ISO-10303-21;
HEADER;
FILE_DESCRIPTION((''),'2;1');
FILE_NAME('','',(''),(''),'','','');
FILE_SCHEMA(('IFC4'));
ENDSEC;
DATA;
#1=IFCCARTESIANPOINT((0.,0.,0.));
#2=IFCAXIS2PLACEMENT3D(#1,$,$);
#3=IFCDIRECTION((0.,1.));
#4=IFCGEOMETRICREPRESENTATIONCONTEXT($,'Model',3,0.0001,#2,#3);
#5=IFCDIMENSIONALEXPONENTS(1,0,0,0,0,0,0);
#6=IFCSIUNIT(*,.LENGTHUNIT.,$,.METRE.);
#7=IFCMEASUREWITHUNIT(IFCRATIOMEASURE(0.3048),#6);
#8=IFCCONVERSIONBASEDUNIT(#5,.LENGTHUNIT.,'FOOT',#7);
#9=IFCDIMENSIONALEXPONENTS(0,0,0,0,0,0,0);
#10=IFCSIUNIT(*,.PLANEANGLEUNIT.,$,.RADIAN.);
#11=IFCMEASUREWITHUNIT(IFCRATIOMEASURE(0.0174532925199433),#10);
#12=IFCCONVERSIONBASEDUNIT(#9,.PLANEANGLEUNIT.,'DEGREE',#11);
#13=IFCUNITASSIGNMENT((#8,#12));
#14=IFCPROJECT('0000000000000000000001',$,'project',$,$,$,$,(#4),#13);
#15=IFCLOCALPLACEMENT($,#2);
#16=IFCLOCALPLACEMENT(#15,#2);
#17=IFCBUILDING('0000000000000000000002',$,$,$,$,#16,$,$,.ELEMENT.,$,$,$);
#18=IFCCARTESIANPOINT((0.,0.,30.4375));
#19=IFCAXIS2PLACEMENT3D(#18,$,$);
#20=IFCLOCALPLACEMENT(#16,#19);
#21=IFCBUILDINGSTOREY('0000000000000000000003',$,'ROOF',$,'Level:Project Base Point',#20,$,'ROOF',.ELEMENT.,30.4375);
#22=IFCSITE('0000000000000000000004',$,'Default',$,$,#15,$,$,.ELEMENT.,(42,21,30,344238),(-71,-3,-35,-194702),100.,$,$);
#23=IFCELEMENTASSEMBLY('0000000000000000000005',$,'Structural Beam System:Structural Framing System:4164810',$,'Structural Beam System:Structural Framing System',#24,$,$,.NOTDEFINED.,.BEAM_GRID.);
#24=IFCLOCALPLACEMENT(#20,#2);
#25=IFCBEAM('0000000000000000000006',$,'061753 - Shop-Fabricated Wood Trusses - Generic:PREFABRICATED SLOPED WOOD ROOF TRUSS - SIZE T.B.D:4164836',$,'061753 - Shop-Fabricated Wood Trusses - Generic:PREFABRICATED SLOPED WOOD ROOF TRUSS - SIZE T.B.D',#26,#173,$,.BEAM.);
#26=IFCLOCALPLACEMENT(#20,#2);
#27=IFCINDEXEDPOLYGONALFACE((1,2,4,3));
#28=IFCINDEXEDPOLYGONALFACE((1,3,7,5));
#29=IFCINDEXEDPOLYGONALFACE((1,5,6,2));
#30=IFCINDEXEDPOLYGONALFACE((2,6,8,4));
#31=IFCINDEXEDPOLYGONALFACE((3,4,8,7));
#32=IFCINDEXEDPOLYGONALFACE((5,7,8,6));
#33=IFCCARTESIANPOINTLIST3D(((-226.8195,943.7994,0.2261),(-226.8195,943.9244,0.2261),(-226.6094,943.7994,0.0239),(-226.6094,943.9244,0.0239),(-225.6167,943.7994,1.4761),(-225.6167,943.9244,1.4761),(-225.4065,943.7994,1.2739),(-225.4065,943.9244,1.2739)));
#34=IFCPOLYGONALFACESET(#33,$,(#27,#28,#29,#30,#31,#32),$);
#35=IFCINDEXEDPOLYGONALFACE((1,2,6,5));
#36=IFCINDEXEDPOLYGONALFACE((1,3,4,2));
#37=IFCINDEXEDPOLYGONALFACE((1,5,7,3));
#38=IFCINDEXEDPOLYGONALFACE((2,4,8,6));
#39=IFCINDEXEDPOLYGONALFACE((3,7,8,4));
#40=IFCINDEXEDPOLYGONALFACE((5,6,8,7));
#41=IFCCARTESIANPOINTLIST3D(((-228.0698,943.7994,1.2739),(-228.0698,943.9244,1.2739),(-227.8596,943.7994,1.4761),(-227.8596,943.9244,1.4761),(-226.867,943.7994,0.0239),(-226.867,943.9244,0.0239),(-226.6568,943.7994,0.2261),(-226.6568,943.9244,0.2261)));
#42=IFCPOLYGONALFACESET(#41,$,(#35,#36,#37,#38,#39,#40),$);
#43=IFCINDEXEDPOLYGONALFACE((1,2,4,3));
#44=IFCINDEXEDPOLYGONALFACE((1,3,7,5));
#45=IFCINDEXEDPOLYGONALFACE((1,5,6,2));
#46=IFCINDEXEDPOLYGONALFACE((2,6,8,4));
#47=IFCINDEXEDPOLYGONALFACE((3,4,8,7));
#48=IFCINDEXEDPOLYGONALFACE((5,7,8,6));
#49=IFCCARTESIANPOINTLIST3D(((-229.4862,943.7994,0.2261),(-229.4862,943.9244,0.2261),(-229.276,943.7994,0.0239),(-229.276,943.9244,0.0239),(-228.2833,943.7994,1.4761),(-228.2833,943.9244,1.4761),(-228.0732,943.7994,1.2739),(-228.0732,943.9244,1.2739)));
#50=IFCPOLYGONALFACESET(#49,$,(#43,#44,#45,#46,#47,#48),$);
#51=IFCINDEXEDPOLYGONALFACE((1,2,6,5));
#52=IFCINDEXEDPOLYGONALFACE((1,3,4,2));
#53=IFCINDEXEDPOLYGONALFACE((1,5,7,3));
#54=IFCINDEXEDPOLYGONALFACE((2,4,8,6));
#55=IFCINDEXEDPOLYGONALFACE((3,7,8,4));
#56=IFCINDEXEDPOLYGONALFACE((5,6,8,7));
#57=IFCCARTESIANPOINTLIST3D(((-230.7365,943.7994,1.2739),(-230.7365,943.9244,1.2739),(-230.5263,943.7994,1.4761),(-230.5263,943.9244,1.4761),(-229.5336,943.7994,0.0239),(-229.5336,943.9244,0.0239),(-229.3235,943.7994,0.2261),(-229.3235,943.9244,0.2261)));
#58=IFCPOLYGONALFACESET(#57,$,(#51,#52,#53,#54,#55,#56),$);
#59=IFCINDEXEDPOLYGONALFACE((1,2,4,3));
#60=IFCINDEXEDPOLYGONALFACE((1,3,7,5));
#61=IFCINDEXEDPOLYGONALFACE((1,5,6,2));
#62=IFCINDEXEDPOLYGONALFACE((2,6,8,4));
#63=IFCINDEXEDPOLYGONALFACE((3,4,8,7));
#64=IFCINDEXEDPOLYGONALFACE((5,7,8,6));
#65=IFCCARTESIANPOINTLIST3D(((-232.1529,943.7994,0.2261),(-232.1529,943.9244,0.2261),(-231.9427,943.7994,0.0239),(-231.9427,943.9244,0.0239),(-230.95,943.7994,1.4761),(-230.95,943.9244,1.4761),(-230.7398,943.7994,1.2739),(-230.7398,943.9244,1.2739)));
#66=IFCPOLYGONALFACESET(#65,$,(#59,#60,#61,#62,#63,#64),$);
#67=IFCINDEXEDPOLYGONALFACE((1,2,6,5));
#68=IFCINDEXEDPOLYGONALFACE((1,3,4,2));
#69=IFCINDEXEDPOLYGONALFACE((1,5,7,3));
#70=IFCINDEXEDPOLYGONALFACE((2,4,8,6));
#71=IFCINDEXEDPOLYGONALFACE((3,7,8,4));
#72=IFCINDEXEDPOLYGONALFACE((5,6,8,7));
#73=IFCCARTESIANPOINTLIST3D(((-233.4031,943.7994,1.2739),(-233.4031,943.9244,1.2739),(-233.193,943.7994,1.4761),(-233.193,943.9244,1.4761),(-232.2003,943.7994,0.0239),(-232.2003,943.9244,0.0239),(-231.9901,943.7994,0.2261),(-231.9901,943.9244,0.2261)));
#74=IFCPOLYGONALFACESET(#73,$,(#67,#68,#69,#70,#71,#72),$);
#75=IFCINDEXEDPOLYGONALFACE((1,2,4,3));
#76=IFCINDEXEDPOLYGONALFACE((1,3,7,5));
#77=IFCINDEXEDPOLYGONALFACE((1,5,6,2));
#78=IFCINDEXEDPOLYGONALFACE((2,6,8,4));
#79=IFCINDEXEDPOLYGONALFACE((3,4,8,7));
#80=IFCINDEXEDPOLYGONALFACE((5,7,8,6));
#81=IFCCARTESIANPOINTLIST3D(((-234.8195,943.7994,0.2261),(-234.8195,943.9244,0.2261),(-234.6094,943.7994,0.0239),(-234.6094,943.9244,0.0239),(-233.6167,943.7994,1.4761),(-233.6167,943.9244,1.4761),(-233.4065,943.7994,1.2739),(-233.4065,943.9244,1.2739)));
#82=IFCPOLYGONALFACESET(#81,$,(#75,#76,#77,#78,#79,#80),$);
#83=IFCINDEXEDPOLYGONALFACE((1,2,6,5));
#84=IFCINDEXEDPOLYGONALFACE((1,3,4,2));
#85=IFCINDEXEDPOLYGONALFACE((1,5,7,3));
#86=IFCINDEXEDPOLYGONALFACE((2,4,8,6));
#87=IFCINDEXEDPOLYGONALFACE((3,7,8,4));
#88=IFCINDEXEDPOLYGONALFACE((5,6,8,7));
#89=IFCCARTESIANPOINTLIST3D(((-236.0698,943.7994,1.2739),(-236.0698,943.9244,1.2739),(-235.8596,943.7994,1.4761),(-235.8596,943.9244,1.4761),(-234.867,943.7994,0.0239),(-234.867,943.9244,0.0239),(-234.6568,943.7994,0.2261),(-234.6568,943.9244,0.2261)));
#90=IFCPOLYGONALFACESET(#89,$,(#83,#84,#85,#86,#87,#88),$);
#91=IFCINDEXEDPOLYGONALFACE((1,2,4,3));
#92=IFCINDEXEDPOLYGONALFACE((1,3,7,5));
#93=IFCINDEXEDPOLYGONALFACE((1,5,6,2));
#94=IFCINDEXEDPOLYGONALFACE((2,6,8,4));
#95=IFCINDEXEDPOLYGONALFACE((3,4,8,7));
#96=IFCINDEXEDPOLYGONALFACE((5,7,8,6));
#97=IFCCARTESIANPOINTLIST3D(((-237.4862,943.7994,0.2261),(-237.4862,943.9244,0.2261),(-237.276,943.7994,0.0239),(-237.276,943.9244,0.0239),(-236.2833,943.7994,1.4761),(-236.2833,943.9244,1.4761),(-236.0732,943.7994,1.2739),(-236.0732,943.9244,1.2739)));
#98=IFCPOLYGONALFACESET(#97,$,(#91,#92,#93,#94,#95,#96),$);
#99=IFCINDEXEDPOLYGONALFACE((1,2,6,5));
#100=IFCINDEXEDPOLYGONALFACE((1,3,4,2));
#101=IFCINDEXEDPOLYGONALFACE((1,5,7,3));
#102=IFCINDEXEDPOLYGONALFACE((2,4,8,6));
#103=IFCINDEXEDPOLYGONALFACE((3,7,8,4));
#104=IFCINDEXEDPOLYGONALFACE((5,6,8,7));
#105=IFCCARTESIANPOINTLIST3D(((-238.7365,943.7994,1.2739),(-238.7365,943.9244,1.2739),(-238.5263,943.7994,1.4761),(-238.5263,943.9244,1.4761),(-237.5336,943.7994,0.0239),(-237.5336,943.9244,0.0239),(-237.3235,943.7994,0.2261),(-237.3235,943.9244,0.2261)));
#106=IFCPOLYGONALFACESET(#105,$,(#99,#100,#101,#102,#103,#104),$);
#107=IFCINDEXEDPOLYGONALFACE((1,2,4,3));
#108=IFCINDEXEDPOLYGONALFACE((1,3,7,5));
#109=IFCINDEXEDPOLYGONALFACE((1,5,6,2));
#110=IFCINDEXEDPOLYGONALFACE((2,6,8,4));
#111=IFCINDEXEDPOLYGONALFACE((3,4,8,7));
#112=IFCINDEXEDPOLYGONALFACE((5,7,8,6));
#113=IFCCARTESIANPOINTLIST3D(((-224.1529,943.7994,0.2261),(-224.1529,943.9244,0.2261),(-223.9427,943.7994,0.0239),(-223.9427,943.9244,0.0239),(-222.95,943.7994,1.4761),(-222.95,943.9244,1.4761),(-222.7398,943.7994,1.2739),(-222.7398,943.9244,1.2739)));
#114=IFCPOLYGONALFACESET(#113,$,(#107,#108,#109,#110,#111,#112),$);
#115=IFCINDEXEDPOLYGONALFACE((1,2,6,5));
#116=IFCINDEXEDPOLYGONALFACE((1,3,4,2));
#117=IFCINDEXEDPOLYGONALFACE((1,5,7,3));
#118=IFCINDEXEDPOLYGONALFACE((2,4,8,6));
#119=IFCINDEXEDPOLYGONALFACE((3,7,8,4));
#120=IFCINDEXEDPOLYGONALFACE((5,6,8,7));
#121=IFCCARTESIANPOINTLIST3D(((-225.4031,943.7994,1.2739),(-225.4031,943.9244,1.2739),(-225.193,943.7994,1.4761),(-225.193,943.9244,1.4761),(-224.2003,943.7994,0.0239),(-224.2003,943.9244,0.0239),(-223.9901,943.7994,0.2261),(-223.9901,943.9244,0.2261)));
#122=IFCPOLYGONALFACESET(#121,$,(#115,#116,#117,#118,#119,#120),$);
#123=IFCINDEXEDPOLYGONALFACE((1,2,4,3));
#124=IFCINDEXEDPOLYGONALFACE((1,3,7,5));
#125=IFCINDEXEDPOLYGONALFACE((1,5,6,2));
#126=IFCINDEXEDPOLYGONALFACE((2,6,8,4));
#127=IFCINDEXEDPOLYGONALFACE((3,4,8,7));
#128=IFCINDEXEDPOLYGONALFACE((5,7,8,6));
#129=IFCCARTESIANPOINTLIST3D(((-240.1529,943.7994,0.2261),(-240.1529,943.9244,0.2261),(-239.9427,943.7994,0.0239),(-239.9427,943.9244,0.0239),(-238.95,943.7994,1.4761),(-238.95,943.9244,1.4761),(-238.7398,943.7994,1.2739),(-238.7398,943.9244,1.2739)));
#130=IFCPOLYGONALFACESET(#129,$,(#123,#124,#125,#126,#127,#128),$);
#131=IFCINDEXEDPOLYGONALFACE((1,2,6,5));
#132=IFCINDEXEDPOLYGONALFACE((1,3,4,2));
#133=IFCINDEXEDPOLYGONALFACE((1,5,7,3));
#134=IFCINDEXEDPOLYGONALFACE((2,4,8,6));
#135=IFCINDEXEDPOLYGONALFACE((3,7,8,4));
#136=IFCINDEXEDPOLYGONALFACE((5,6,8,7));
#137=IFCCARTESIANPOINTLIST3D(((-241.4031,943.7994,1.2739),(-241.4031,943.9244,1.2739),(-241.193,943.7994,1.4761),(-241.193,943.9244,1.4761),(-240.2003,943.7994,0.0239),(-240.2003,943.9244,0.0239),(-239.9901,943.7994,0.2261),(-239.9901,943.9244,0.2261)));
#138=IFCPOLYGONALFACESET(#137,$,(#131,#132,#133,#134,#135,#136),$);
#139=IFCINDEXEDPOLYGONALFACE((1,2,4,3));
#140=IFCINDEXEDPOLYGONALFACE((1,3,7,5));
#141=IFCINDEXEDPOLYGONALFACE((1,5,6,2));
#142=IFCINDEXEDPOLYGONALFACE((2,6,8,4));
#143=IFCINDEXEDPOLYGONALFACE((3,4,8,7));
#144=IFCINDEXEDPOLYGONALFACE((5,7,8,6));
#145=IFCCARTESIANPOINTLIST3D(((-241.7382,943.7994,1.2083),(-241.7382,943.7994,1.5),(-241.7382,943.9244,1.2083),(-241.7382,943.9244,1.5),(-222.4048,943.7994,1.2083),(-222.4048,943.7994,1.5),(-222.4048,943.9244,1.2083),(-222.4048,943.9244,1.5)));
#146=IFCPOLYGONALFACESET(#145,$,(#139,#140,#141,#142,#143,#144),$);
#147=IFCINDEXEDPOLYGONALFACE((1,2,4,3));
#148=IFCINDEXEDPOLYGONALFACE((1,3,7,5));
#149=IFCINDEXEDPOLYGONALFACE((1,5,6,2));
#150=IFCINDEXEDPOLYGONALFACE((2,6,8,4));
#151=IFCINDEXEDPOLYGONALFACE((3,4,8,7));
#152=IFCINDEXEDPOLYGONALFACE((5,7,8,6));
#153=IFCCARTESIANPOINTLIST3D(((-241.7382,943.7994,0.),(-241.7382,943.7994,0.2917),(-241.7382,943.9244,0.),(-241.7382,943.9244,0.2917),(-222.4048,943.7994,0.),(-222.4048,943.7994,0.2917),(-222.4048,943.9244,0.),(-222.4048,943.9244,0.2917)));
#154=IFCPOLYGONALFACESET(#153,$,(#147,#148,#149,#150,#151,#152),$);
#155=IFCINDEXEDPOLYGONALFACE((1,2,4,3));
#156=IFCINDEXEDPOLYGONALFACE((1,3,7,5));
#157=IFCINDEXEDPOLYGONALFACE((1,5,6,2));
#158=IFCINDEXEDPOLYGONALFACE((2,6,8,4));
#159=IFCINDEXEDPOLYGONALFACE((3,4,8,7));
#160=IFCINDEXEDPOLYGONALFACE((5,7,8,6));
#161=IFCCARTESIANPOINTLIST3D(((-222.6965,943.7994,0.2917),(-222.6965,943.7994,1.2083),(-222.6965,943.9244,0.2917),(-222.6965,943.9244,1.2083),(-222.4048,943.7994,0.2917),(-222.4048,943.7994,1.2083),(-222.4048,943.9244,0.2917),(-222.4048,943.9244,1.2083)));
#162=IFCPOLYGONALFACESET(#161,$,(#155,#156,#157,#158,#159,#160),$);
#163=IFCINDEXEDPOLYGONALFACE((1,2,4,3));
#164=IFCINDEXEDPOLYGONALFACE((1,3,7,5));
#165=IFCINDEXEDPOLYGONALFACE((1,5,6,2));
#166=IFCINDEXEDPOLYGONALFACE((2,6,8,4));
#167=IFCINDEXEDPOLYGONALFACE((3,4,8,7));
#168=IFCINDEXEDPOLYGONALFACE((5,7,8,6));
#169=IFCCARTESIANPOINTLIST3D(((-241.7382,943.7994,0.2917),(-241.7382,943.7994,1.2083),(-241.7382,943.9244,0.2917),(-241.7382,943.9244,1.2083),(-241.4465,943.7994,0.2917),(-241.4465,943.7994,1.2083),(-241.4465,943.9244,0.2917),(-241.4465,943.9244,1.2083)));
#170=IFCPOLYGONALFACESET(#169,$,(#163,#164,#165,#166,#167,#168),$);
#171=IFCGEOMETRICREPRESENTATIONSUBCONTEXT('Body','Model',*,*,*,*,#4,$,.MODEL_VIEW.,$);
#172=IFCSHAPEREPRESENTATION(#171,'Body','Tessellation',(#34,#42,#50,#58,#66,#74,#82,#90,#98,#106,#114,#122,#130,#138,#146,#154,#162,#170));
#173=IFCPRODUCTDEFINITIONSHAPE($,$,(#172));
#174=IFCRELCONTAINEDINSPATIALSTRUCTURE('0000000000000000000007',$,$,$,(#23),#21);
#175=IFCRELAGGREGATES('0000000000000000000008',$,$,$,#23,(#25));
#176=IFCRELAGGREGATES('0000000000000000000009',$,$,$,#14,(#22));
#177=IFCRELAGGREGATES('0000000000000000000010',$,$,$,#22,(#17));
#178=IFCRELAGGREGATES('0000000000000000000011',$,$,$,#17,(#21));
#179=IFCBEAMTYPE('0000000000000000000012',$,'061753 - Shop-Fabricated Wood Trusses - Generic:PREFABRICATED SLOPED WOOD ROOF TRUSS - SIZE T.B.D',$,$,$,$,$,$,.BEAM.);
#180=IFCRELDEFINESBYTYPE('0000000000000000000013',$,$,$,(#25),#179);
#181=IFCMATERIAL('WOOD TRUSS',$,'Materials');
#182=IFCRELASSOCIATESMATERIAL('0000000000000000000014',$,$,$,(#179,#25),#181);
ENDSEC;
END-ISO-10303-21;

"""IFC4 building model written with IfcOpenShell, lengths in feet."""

from ifc_helpers import new_model, entity, si_unit, converted_unit, direction, frame, frame_2d, origin, origin_2d_with_axis, place, context, subcontext, project, spatial, rectangle, extrude, source, transform, mapped, material, material_profile, profile_set, profile_usage, type_object, type_shapes, element, aggregate, save


model = new_model("IFC4")

# Units and contexts
model_context = context("Model", 3, precision=0.0001, world=origin(), true_north=direction((0.0, 1.0)))
body_context = subcontext(model_context, "Body", "Model", "MODEL_VIEW")
ifc_project = project(units=[converted_unit("LENGTHUNIT", "FOOT", entity("IfcRatioMeasure", 0.3048), si_unit("LENGTHUNIT", "METRE"), dimensions=[1, 0, 0, 0, 0, 0, 0]), converted_unit("PLANEANGLEUNIT", "DEGREE", entity("IfcRatioMeasure", 0.0174532925199433), si_unit("PLANEANGLEUNIT", "RADIAN"), dimensions=[0, 0, 0, 0, 0, 0, 0])], contexts=[model_context])

# Site, building, storey
site_placement = place(None, origin())
site = spatial("IfcSite", under=ifc_project, at=site_placement, Name="Default", CompositionType="ELEMENT", RefLatitude=(42, 21, 30, 344238), RefLongitude=(-71, -3, -35, -194702), RefElevation=100.0)
building_placement = place(site_placement, origin())
building = spatial("IfcBuilding", under=site, at=building_placement, CompositionType="ELEMENT")
storey_placement = place(building_placement, frame((0.0, 0.0, 30.4375)))
storey = spatial("IfcBuildingStorey", under=building, at=storey_placement, Name="ROOF", ObjectType="Level:Project Base Point", LongName="ROOF", CompositionType="ELEMENT", Elevation=30.4375)

# Element assembly, beam
assembly_1_placement = place(storey_placement, origin())
assembly_1 = element("IfcElementAssembly", 1, at=assembly_1_placement, inside=storey, Name="Structural Beam System:Structural Framing System:4164810", ObjectType="Structural Beam System:Structural Framing System", AssemblyPlace="NOTDEFINED", PredefinedType="BEAM_GRID")
ifc_material_1 = material(Name="WOOD TRUSS", Category="Materials")
ifc_material_profile_1 = material_profile(ifc_material_1, rectangle(XDim=1.7347, YDim=0.125, at=origin_2d_with_axis()), Name="PREFABRICATED SLOPED WOOD ROOF TRUSS - SIZE T.B.D")
ifc_material_profile_2 = material_profile(ifc_material_1, rectangle(XDim=1.7347, YDim=0.125, at=frame_2d((0.0, 0.0), x_axis=(1.0, 0.0))), Name="PREFABRICATED SLOPED WOOD ROOF TRUSS - SIZE T.B.D")
ifc_material_profile_3 = material_profile(ifc_material_1, rectangle(XDim=1.7347, YDim=0.125, at=origin_2d_with_axis()), Name="PREFABRICATED SLOPED WOOD ROOF TRUSS - SIZE T.B.D")
ifc_material_profile_4 = material_profile(ifc_material_1, rectangle(XDim=1.7347, YDim=0.125, at=origin_2d_with_axis()), Name="PREFABRICATED SLOPED WOOD ROOF TRUSS - SIZE T.B.D")
ifc_material_profile_5 = material_profile(ifc_material_1, rectangle(XDim=1.7347, YDim=0.125, at=frame_2d((0.0, 0.0), x_axis=(1.0, 0.0))), Name="PREFABRICATED SLOPED WOOD ROOF TRUSS - SIZE T.B.D")
ifc_material_profile_6 = material_profile(ifc_material_1, rectangle(XDim=1.7347, YDim=0.125, at=frame_2d((0.0, 0.0), x_axis=(1.0, 0.0))), Name="PREFABRICATED SLOPED WOOD ROOF TRUSS - SIZE T.B.D")
ifc_material_profile_7 = material_profile(ifc_material_1, rectangle(XDim=1.7347, YDim=0.125, at=frame_2d((0.0, 0.0), x_axis=(1.0, 0.0))), Name="PREFABRICATED SLOPED WOOD ROOF TRUSS - SIZE T.B.D")
ifc_material_profile_8 = material_profile(ifc_material_1, rectangle(XDim=1.7347, YDim=0.125, at=frame_2d((0.0, 0.0), x_axis=(1.0, 0.0))), Name="PREFABRICATED SLOPED WOOD ROOF TRUSS - SIZE T.B.D")
ifc_material_profile_9 = material_profile(ifc_material_1, rectangle(XDim=1.7347, YDim=0.125, at=origin_2d_with_axis()), Name="PREFABRICATED SLOPED WOOD ROOF TRUSS - SIZE T.B.D")
ifc_material_profile_10 = material_profile(ifc_material_1, rectangle(XDim=1.7347, YDim=0.125, at=frame_2d((0.0, 0.0), x_axis=(1.0, 0.0))), Name="PREFABRICATED SLOPED WOOD ROOF TRUSS - SIZE T.B.D")
ifc_material_profile_11 = material_profile(ifc_material_1, rectangle(XDim=0.2917, YDim=0.125, at=frame_2d((0.0, 0.0), x_axis=(1.0, 0.0))), Name="PREFABRICATED SLOPED WOOD ROOF TRUSS - SIZE T.B.D")
ifc_material_profile_12 = material_profile(ifc_material_1, rectangle(XDim=0.2917, YDim=0.125, at=frame_2d((0.0, 0.0), x_axis=(1.0, 0.0))), Name="PREFABRICATED SLOPED WOOD ROOF TRUSS - SIZE T.B.D")
ifc_material_profile_13 = material_profile(ifc_material_1, rectangle(XDim=0.9167, YDim=0.125, at=frame_2d((0.0, 0.0), x_axis=(1.0, 0.0))), Name="PREFABRICATED SLOPED WOOD ROOF TRUSS - SIZE T.B.D")
ifc_material_profile_14 = material_profile(ifc_material_1, rectangle(XDim=0.9167, YDim=0.125, at=frame_2d((0.0, 0.0), x_axis=(1.0, 0.0))), Name="PREFABRICATED SLOPED WOOD ROOF TRUSS - SIZE T.B.D")
ifc_profile_set_1 = profile_set([ifc_material_profile_1, ifc_material_profile_2, ifc_material_profile_3, ifc_material_profile_4, ifc_material_profile_5, ifc_material_profile_6, ifc_material_profile_7, ifc_material_profile_8, ifc_material_profile_9, ifc_material_profile_10, ifc_material_profile_11, ifc_material_profile_12, ifc_material_profile_13, ifc_material_profile_14], Name="PREFABRICATED SLOPED WOOD ROOF TRUSS - SIZE T.B.D")
beam_type_1 = type_object("IfcBeamType", Name="061753 - Shop-Fabricated Wood Trusses - Generic:PREFABRICATED SLOPED WOOD ROOF TRUSS - SIZE T.B.D", PredefinedType="BEAM", material=ifc_profile_set_1)
shared_shape_1 = source(origin(), body_context, "Body", "SweptSolid", [
    extrude(rectangle(XDim=1.7347, YDim=0.125, at=frame_2d((0.0, 0.0), x_axis=(1.0, 0.0))), frame((5.8534, 0.0, 0.1011), z_axis=(0.720569, 0.0, -0.693383), x_axis=(0.693383, 0.0, 0.720569)), (0.0, 0.0, 1.0), 0.2917),
    extrude(rectangle(XDim=1.7347, YDim=0.125, at=frame_2d((0.0, 0.0), x_axis=(1.0, 0.0))), frame((4.6031, 0.0, -0.1011), z_axis=(0.720569, 0.0, 0.693383), x_axis=(0.693383, 0.0, -0.720569)), (0.0, 0.0, 1.0), 0.2917),
    extrude(rectangle(XDim=1.7347, YDim=0.125, at=frame_2d((0.0, 0.0), x_axis=(1.0, 0.0))), frame((3.1867, 0.0, 0.1011), z_axis=(0.720569, 0.0, -0.693383), x_axis=(0.693383, 0.0, 0.720569)), (0.0, 0.0, 1.0), 0.2917),
    extrude(rectangle(XDim=1.7347, YDim=0.125, at=frame_2d((0.0, 0.0), x_axis=(1.0, 0.0))), frame((1.9364, 0.0, -0.1011), z_axis=(0.720569, 0.0, 0.693383), x_axis=(0.693383, 0.0, -0.720569)), (0.0, 0.0, 1.0), 0.2917),
    extrude(rectangle(XDim=1.7347, YDim=0.125, at=frame_2d((0.0, 0.0), x_axis=(1.0, 0.0))), frame((0.5201, 0.0, 0.1011), z_axis=(0.720569, 0.0, -0.693383), x_axis=(0.693383, 0.0, 0.720569)), (0.0, 0.0, 1.0), 0.2917),
    extrude(rectangle(XDim=1.7347, YDim=0.125, at=origin_2d_with_axis()), frame((-0.7302, 0.0, -0.1011), z_axis=(0.720569, 0.0, 0.693383), x_axis=(0.693383, 0.0, -0.720569)), (0.0, 0.0, 1.0), 0.2917),
    extrude(rectangle(XDim=1.7347, YDim=0.125, at=frame_2d((0.0, 0.0), x_axis=(1.0, 0.0))), frame((-2.1466, 0.0, 0.1011), z_axis=(0.720569, 0.0, -0.693383), x_axis=(0.693383, 0.0, 0.720569)), (0.0, 0.0, 1.0), 0.2917),
    extrude(rectangle(XDim=1.7347, YDim=0.125, at=frame_2d((0.0, 0.0), x_axis=(1.0, 0.0))), frame((-3.3969, 0.0, -0.1011), z_axis=(0.720569, 0.0, 0.693383), x_axis=(0.693383, 0.0, -0.720569)), (0.0, 0.0, 1.0), 0.2917),
    extrude(rectangle(XDim=1.7347, YDim=0.125, at=origin_2d_with_axis()), frame((-4.8133, 0.0, 0.1011), z_axis=(0.720569, 0.0, -0.693383), x_axis=(0.693383, 0.0, 0.720569)), (0.0, 0.0, 1.0), 0.2917),
    extrude(rectangle(XDim=1.7347, YDim=0.125, at=frame_2d((0.0, 0.0), x_axis=(1.0, 0.0))), frame((-6.0636, 0.0, -0.1011), z_axis=(0.720569, 0.0, 0.693383), x_axis=(0.693383, 0.0, -0.720569)), (0.0, 0.0, 1.0), 0.2917),
    extrude(rectangle(XDim=1.7347, YDim=0.125, at=frame_2d((0.0, 0.0), x_axis=(1.0, 0.0))), frame((8.5201, 0.0, 0.1011), z_axis=(0.720569, 0.0, -0.693383), x_axis=(0.693383, 0.0, 0.720569)), (0.0, 0.0, 1.0), 0.2917),
    extrude(rectangle(XDim=1.7347, YDim=0.125, at=origin_2d_with_axis()), frame((7.2698, 0.0, -0.1011), z_axis=(0.720569, 0.0, 0.693383), x_axis=(0.693383, 0.0, -0.720569)), (0.0, 0.0, 1.0), 0.2917),
    extrude(rectangle(XDim=1.7347, YDim=0.125, at=frame_2d((0.0, 0.0), x_axis=(1.0, 0.0))), frame((-7.4799, 0.0, 0.1011), z_axis=(0.720569, 0.0, -0.693383), x_axis=(0.693383, 0.0, 0.720569)), (0.0, 0.0, 1.0), 0.2917),
    extrude(rectangle(XDim=1.7347, YDim=0.125, at=origin_2d_with_axis()), frame((-8.7302, 0.0, -0.1011), z_axis=(0.720569, 0.0, 0.693383), x_axis=(0.693383, 0.0, -0.720569)), (0.0, 0.0, 1.0), 0.2917),
    extrude(rectangle(XDim=0.2917, YDim=0.125, at=frame_2d((0.0, 0.0), x_axis=(1.0, 0.0))), frame((-9.6667, 0.0, 0.6042), z_axis=(1.0, 0.0, 0.0), x_axis=(0.0, 0.0, -1.0)), (0.0, 0.0, 1.0), 19.3333),
    extrude(rectangle(XDim=0.2917, YDim=0.125, at=frame_2d((0.0, 0.0), x_axis=(1.0, 0.0))), frame((-9.6667, 0.0, -0.6042), z_axis=(1.0, 0.0, 0.0), x_axis=(0.0, 0.0, -1.0)), (0.0, 0.0, 1.0), 19.3333),
    extrude(rectangle(XDim=0.9167, YDim=0.125, at=frame_2d((0.0, 0.0), x_axis=(1.0, 0.0))), frame((9.375, 0.0, 0.0), z_axis=(1.0, 0.0, 0.0), x_axis=(0.0, 0.0, -1.0)), (0.0, 0.0, 1.0), 0.2917),
    extrude(rectangle(XDim=0.9167, YDim=0.125, at=frame_2d((0.0, 0.0), x_axis=(1.0, 0.0))), frame((-9.6667, 0.0, 0.0), z_axis=(1.0, 0.0, 0.0), x_axis=(0.0, 0.0, -1.0)), (0.0, 0.0, 1.0), 0.2917),
])
type_shapes(beam_type_1, [shared_shape_1])
ifc_profile_usage_1 = profile_usage(ifc_profile_set_1, cardinal=8)
beam_1_placement = place(assembly_1_placement, frame((-232.0715, 943.8619, 0.75)))
beam_1 = element("IfcBeam", 2, at=beam_1_placement, type_object=beam_type_1, material=ifc_profile_usage_1, Name="061753 - Shop-Fabricated Wood Trusses - Generic:PREFABRICATED SLOPED WOOD ROOF TRUSS - SIZE T.B.D:4164836", ObjectType="061753 - Shop-Fabricated Wood Trusses - Generic:PREFABRICATED SLOPED WOOD ROOF TRUSS - SIZE T.B.D", PredefinedType="BEAM", context=body_context, shape_type="MappedRepresentation", body=[
    mapped(shared_shape_1, transform((0.0, 0.0, 0.0), scale=1.0)),
])
aggregate(assembly_1, [beam_1])

save(model, "model.ifc")
